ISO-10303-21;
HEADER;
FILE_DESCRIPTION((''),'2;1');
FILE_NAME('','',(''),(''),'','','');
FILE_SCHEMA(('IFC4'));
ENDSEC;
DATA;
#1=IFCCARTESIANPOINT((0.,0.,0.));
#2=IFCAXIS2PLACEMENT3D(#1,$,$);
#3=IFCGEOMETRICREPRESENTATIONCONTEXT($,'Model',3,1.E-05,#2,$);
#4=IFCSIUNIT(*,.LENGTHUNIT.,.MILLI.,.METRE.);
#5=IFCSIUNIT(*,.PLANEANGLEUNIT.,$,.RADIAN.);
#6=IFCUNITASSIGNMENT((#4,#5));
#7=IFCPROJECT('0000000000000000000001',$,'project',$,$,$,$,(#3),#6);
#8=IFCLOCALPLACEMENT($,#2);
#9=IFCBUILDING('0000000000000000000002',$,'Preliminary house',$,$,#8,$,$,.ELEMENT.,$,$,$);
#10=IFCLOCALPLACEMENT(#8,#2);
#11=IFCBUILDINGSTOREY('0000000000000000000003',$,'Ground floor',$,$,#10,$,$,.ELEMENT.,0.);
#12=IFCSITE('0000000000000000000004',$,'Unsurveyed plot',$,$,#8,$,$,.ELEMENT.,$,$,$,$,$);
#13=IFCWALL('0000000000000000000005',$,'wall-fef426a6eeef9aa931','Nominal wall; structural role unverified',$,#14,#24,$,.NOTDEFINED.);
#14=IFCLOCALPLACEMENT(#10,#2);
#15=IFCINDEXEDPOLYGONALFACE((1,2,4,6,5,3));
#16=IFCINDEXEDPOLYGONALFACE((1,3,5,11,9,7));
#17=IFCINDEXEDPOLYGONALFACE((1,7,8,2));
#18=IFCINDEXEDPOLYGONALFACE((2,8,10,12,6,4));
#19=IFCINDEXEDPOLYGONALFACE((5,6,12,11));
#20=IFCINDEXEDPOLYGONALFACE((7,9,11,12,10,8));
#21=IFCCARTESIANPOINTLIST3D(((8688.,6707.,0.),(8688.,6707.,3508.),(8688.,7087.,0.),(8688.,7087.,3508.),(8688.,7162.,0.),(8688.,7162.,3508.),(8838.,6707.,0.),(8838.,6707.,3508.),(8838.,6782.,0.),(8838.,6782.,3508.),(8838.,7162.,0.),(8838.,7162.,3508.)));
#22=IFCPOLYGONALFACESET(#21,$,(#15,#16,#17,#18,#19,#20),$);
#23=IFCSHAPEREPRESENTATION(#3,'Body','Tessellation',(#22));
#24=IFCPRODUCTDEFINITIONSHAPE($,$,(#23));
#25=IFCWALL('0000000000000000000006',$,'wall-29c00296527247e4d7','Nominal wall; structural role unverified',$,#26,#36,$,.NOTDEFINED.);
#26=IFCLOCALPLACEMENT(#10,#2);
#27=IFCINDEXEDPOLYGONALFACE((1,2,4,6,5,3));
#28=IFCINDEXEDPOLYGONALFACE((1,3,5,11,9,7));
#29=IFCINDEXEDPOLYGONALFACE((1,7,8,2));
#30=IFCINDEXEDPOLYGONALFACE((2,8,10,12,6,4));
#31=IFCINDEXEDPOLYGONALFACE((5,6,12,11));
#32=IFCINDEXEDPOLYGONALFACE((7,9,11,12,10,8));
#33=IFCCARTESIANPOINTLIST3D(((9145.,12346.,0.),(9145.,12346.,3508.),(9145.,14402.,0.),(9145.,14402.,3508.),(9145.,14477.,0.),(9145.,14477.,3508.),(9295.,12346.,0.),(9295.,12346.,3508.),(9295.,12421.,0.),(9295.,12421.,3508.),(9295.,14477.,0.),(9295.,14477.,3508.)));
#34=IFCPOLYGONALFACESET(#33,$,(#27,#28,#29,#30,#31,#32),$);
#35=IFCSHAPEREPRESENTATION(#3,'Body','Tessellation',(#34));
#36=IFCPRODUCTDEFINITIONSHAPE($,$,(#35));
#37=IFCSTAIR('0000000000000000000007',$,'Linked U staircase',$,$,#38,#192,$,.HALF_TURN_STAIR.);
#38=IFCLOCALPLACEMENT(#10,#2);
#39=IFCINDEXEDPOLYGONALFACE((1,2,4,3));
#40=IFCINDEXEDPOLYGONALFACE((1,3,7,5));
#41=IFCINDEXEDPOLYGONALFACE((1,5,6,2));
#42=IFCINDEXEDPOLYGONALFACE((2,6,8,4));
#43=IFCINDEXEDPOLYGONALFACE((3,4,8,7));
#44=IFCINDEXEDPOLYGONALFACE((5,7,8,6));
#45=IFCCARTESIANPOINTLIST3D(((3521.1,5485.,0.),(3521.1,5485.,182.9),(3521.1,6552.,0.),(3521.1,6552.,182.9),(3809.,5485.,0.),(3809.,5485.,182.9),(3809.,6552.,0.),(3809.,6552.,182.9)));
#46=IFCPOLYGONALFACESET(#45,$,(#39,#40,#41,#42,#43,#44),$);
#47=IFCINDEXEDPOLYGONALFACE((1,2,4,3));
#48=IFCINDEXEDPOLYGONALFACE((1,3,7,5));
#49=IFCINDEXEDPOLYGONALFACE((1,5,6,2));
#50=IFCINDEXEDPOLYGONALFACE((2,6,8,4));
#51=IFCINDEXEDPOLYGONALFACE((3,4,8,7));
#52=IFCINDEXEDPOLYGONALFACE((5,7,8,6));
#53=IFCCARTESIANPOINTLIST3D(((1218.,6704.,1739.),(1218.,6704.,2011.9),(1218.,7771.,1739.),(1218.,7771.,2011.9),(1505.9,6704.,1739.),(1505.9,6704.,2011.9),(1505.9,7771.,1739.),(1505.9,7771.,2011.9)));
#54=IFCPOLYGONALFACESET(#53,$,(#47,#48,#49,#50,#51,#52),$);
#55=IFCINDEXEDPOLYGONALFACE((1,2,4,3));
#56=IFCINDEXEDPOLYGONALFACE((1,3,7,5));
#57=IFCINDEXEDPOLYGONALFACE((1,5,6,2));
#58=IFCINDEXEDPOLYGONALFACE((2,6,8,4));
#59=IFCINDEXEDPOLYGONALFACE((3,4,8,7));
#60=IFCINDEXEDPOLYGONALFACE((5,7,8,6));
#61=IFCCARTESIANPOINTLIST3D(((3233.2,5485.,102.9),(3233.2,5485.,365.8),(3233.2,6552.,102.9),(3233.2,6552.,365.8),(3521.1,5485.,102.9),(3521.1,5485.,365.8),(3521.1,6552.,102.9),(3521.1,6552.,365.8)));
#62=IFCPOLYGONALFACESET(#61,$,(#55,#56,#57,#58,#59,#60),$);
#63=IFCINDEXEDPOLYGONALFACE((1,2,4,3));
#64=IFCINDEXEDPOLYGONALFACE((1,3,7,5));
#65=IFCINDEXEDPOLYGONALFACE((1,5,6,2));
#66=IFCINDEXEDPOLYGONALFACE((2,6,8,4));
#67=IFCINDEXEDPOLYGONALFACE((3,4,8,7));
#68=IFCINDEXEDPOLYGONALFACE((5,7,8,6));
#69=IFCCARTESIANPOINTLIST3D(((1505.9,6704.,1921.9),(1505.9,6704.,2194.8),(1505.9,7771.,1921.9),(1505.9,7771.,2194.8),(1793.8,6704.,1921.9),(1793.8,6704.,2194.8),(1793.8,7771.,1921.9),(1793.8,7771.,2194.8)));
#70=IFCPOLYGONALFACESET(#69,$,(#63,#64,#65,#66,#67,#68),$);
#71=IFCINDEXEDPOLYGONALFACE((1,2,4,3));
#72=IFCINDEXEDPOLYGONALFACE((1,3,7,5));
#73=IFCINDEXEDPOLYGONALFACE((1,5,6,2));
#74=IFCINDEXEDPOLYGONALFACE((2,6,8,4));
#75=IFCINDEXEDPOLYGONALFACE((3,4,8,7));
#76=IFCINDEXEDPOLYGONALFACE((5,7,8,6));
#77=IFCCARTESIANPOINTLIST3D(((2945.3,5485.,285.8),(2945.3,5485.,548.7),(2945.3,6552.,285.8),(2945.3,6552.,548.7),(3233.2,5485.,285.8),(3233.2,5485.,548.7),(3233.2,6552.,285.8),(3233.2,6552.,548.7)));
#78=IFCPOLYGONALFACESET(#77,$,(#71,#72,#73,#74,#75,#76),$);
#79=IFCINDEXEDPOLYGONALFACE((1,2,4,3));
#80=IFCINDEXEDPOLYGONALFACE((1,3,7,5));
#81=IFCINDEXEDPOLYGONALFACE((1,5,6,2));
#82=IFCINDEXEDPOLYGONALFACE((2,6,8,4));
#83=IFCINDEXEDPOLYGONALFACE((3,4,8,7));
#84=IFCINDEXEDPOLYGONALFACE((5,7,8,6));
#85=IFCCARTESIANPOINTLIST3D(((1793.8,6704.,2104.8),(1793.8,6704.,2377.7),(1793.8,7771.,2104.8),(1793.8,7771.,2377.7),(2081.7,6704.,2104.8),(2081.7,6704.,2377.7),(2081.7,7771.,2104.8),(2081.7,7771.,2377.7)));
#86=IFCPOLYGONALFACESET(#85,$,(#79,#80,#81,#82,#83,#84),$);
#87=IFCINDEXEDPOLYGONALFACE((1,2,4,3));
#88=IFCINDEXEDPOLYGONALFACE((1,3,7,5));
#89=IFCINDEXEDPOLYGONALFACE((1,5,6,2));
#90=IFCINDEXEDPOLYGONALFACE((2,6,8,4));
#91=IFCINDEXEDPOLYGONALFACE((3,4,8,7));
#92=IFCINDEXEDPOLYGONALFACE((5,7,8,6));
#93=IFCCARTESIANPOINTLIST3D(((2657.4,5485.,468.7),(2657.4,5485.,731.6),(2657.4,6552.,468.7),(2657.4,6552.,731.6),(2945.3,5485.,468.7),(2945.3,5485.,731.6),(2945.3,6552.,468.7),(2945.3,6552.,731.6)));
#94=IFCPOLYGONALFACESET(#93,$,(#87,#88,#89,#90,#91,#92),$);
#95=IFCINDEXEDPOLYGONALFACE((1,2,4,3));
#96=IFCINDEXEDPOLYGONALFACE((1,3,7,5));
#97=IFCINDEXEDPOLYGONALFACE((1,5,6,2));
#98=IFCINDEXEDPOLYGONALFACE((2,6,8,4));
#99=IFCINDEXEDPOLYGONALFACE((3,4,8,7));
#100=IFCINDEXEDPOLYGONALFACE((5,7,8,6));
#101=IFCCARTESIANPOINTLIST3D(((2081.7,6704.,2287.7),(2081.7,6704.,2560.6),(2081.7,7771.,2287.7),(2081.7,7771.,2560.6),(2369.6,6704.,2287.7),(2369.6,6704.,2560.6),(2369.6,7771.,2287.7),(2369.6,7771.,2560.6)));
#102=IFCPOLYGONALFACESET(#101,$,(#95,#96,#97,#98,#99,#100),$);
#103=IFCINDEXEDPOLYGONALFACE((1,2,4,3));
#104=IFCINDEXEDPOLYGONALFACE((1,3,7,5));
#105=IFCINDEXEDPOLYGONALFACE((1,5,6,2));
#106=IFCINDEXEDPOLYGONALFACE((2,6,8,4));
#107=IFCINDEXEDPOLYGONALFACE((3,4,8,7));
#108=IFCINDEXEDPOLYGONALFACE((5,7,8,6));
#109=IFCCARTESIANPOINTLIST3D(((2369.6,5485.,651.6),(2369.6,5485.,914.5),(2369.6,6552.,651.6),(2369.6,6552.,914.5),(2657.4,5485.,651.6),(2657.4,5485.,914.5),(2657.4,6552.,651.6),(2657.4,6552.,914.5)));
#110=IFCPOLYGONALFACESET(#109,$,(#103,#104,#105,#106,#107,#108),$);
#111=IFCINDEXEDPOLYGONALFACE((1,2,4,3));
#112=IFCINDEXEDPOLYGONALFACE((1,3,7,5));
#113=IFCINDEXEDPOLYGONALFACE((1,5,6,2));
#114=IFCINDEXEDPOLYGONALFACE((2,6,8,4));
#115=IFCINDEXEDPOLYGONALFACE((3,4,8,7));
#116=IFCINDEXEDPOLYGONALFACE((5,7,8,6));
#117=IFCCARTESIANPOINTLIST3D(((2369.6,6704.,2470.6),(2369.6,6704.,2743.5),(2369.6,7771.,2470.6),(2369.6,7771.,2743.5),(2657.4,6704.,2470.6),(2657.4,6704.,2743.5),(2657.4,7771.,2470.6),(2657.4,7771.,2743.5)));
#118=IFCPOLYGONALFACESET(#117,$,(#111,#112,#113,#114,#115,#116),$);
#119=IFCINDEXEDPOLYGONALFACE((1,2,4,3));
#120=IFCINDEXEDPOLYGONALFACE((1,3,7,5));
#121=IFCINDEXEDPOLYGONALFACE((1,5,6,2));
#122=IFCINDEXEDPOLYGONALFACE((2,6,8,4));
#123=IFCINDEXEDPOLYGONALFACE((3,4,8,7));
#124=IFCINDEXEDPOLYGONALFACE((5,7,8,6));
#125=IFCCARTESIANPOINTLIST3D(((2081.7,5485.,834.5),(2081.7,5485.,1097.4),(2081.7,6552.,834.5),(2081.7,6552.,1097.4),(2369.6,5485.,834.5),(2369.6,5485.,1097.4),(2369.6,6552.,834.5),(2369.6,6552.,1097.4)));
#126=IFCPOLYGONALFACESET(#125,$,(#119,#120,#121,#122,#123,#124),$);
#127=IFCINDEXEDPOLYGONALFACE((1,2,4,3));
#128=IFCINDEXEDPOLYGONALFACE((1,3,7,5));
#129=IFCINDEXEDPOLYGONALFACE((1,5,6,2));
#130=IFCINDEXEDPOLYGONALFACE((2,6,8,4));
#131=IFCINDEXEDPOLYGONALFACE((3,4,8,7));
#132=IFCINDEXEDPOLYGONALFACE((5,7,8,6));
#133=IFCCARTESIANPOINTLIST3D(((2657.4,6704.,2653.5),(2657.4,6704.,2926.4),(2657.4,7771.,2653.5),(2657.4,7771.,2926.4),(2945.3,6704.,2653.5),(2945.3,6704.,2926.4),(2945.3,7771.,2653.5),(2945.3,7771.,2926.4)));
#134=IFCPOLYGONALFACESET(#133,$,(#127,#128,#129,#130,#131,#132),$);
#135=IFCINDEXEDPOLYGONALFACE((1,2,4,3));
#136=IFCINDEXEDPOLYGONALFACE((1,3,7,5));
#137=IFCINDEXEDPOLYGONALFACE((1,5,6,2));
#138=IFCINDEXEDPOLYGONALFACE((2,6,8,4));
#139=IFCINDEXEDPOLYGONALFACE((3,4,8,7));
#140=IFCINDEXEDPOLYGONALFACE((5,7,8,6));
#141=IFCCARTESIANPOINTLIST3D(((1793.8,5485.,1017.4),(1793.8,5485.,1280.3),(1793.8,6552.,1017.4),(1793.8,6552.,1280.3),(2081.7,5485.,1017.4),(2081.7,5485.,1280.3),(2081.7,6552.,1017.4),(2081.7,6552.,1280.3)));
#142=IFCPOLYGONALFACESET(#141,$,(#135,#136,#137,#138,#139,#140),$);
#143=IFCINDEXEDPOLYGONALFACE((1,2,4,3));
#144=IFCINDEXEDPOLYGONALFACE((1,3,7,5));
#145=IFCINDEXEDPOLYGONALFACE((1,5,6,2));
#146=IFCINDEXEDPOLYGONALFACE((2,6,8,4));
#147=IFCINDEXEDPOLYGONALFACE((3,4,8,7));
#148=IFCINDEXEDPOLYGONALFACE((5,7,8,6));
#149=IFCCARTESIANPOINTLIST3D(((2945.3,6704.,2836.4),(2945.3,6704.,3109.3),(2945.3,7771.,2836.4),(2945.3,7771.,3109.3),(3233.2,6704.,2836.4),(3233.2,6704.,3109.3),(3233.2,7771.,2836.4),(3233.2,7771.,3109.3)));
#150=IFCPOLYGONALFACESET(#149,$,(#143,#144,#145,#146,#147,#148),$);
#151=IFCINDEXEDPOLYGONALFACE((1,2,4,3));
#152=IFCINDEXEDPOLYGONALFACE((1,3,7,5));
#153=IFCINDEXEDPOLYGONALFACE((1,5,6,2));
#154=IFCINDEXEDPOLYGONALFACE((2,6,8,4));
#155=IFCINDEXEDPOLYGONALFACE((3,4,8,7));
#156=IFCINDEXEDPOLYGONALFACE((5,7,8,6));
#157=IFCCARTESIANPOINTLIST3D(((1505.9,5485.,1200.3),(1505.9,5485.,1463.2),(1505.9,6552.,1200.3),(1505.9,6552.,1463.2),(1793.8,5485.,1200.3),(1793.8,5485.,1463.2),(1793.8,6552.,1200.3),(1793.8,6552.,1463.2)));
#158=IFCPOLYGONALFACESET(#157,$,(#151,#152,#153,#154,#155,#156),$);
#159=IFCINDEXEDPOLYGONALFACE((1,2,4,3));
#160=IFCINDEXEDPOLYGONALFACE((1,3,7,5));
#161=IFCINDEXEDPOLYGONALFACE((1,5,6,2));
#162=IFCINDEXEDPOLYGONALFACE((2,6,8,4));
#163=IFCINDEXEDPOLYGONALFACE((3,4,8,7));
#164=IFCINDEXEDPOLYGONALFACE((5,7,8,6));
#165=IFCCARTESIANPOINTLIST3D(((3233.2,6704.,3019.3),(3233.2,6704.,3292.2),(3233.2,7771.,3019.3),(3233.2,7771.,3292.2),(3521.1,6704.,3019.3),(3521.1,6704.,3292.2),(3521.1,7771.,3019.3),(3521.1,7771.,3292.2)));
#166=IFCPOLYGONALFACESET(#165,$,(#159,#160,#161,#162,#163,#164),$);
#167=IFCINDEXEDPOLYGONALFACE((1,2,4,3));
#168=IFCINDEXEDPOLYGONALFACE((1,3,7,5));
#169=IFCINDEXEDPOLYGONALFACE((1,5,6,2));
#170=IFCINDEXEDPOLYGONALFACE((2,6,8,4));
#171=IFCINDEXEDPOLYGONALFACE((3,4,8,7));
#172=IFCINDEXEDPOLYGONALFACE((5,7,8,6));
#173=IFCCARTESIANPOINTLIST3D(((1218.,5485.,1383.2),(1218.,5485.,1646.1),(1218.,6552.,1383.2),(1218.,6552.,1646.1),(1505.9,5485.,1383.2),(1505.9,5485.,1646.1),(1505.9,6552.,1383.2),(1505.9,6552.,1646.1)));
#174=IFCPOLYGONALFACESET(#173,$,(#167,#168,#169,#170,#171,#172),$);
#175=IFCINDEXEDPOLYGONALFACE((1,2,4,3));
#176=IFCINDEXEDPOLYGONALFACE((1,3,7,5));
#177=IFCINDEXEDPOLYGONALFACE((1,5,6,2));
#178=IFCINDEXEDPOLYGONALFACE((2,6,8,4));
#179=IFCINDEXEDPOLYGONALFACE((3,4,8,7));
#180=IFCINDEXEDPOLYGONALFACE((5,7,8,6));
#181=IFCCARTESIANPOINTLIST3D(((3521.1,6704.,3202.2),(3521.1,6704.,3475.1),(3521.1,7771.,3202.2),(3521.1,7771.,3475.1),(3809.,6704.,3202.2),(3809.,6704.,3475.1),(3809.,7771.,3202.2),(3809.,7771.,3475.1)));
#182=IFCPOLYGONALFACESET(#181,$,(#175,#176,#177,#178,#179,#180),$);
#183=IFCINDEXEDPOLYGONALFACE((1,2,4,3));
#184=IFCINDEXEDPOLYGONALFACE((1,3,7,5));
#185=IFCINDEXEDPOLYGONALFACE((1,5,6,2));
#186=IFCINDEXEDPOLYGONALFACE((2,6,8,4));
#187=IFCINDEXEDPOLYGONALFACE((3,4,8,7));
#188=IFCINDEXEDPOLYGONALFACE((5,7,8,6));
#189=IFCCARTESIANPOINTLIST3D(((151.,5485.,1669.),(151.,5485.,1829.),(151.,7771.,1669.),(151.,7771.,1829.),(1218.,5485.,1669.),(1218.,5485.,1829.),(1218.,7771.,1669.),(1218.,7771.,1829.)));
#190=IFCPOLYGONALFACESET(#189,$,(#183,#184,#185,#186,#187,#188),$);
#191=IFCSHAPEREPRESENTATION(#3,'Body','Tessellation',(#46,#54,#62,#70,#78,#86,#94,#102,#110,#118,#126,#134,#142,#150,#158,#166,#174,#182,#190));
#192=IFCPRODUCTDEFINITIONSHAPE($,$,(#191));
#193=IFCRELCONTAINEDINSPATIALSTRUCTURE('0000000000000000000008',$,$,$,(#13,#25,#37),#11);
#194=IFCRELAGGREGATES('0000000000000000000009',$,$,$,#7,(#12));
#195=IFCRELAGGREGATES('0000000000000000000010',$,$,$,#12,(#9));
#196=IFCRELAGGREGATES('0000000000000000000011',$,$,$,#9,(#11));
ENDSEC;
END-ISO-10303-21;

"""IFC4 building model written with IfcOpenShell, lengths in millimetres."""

from ifc_helpers import new_model, si_unit, frame, origin, place, context, project, spatial, polyline, outline, extrude, element, save


model = new_model("IFC4")

# Units and contexts
model_context = context("Model", 3, precision=1e-05, world=origin())
ifc_project = project(units=[si_unit("LENGTHUNIT", "METRE", prefix="MILLI"), si_unit("PLANEANGLEUNIT", "RADIAN")], contexts=[model_context])

# Site, building, storey
placement_1 = place(None, origin())
site = spatial("IfcSite", under=ifc_project, at=placement_1, Name="Unsurveyed plot", CompositionType="ELEMENT")
building = spatial("IfcBuilding", under=site, at=placement_1, Name="Preliminary house", CompositionType="ELEMENT")
placement_2 = place(placement_1, origin())
storey = spatial("IfcBuildingStorey", under=building, at=placement_2, Name="Ground floor", CompositionType="ELEMENT", Elevation=0.0)

# Wall
element("IfcWall", 1, at=placement_2, inside=storey, Name="wall-fef426a6eeef9aa931", Description="Nominal wall; structural role unverified", PredefinedType="NOTDEFINED", context=model_context, shape_type="SweptSolid", body=[
    extrude(outline(polyline([(8688.0, 7087.0), (8688.0, 7162.0), (8838.0, 7162.0), (8838.0, 6782.0), (8838.0, 6707.0), (8688.0, 6707.0), (8688.0, 7087.0)])), origin(), (0.0, 0.0, 1.0), 3508.0),
])

# Wall
element("IfcWall", 2, at=placement_2, inside=storey, Name="wall-29c00296527247e4d7", Description="Nominal wall; structural role unverified", PredefinedType="NOTDEFINED", context=model_context, shape_type="SweptSolid", body=[
    extrude(outline(polyline([(9145.0, 14402.0), (9145.0, 14477.0), (9295.0, 14477.0), (9295.0, 12421.0), (9295.0, 12346.0), (9145.0, 12346.0), (9145.0, 14402.0)])), origin(), (0.0, 0.0, 1.0), 3508.0),
])

# Stair
element("IfcStair", 3, at=placement_2, inside=storey, Name="Linked U staircase", PredefinedType="HALF_TURN_STAIR", context=model_context, shape_type="SweptSolid", body=[
    extrude(outline(polyline([(3809.0, 6552.0), (3521.1, 6552.0), (3521.1, 5485.0), (3809.0, 5485.0), (3809.0, 6552.0)])), origin(), (0.0, 0.0, 1.0), 182.9),
    extrude(outline(polyline([(1505.9, 7771.0), (1218.0, 7771.0), (1218.0, 6704.0), (1505.9, 6704.0), (1505.9, 7771.0)])), frame((0.0, 0.0, 1739.0)), (0.0, 0.0, 1.0), 272.9),
    extrude(outline(polyline([(3521.1, 6552.0), (3233.2, 6552.0), (3233.2, 5485.0), (3521.1, 5485.0), (3521.1, 6552.0)])), frame((0.0, 0.0, 102.9)), (0.0, 0.0, 1.0), 262.9),
    extrude(outline(polyline([(1793.8, 7771.0), (1505.9, 7771.0), (1505.9, 6704.0), (1793.8, 6704.0), (1793.8, 7771.0)])), frame((0.0, 0.0, 1921.9)), (0.0, 0.0, 1.0), 272.9),
    extrude(outline(polyline([(3233.2, 6552.0), (2945.3, 6552.0), (2945.3, 5485.0), (3233.2, 5485.0), (3233.2, 6552.0)])), frame((0.0, 0.0, 285.8)), (0.0, 0.0, 1.0), 262.9),
    extrude(outline(polyline([(2081.7, 7771.0), (1793.8, 7771.0), (1793.8, 6704.0), (2081.7, 6704.0), (2081.7, 7771.0)])), frame((0.0, 0.0, 2104.8)), (0.0, 0.0, 1.0), 272.9),
    extrude(outline(polyline([(2945.3, 6552.0), (2657.4, 6552.0), (2657.4, 5485.0), (2945.3, 5485.0), (2945.3, 6552.0)])), frame((0.0, 0.0, 468.7)), (0.0, 0.0, 1.0), 262.9),
    extrude(outline(polyline([(2369.6, 7771.0), (2081.7, 7771.0), (2081.7, 6704.0), (2369.6, 6704.0), (2369.6, 7771.0)])), frame((0.0, 0.0, 2287.7)), (0.0, 0.0, 1.0), 272.9),
    extrude(outline(polyline([(2657.4, 6552.0), (2369.6, 6552.0), (2369.6, 5485.0), (2657.4, 5485.0), (2657.4, 6552.0)])), frame((0.0, 0.0, 651.6)), (0.0, 0.0, 1.0), 262.9),
    extrude(outline(polyline([(2657.4, 7771.0), (2369.6, 7771.0), (2369.6, 6704.0), (2657.4, 6704.0), (2657.4, 7771.0)])), frame((0.0, 0.0, 2470.6)), (0.0, 0.0, 1.0), 272.9),
    extrude(outline(polyline([(2369.6, 6552.0), (2081.7, 6552.0), (2081.7, 5485.0), (2369.6, 5485.0), (2369.6, 6552.0)])), frame((0.0, 0.0, 834.5)), (0.0, 0.0, 1.0), 262.9),
    extrude(outline(polyline([(2945.3, 7771.0), (2657.4, 7771.0), (2657.4, 6704.0), (2945.3, 6704.0), (2945.3, 7771.0)])), frame((0.0, 0.0, 2653.5)), (0.0, 0.0, 1.0), 272.9),
    extrude(outline(polyline([(2081.7, 6552.0), (1793.8, 6552.0), (1793.8, 5485.0), (2081.7, 5485.0), (2081.7, 6552.0)])), frame((0.0, 0.0, 1017.4)), (0.0, 0.0, 1.0), 262.9),
    extrude(outline(polyline([(3233.2, 7771.0), (2945.3, 7771.0), (2945.3, 6704.0), (3233.2, 6704.0), (3233.2, 7771.0)])), frame((0.0, 0.0, 2836.4)), (0.0, 0.0, 1.0), 272.9),
    extrude(outline(polyline([(1793.8, 6552.0), (1505.9, 6552.0), (1505.9, 5485.0), (1793.8, 5485.0), (1793.8, 6552.0)])), frame((0.0, 0.0, 1200.3)), (0.0, 0.0, 1.0), 262.9),
    extrude(outline(polyline([(3521.1, 7771.0), (3233.2, 7771.0), (3233.2, 6704.0), (3521.1, 6704.0), (3521.1, 7771.0)])), frame((0.0, 0.0, 3019.3)), (0.0, 0.0, 1.0), 272.9),
    extrude(outline(polyline([(1505.9, 6552.0), (1218.0, 6552.0), (1218.0, 5485.0), (1505.9, 5485.0), (1505.9, 6552.0)])), frame((0.0, 0.0, 1383.2)), (0.0, 0.0, 1.0), 262.9),
    extrude(outline(polyline([(3809.0, 7771.0), (3521.1, 7771.0), (3521.1, 6704.0), (3809.0, 6704.0), (3809.0, 7771.0)])), frame((0.0, 0.0, 3202.2)), (0.0, 0.0, 1.0), 272.9),
    extrude(outline(polyline([(1218.0, 7771.0), (151.0, 7771.0), (151.0, 5485.0), (1218.0, 5485.0), (1218.0, 7771.0)])), frame((0.0, 0.0, 1669.0)), (0.0, 0.0, 1.0), 160.0),
])

save(model, "model.ifc")
